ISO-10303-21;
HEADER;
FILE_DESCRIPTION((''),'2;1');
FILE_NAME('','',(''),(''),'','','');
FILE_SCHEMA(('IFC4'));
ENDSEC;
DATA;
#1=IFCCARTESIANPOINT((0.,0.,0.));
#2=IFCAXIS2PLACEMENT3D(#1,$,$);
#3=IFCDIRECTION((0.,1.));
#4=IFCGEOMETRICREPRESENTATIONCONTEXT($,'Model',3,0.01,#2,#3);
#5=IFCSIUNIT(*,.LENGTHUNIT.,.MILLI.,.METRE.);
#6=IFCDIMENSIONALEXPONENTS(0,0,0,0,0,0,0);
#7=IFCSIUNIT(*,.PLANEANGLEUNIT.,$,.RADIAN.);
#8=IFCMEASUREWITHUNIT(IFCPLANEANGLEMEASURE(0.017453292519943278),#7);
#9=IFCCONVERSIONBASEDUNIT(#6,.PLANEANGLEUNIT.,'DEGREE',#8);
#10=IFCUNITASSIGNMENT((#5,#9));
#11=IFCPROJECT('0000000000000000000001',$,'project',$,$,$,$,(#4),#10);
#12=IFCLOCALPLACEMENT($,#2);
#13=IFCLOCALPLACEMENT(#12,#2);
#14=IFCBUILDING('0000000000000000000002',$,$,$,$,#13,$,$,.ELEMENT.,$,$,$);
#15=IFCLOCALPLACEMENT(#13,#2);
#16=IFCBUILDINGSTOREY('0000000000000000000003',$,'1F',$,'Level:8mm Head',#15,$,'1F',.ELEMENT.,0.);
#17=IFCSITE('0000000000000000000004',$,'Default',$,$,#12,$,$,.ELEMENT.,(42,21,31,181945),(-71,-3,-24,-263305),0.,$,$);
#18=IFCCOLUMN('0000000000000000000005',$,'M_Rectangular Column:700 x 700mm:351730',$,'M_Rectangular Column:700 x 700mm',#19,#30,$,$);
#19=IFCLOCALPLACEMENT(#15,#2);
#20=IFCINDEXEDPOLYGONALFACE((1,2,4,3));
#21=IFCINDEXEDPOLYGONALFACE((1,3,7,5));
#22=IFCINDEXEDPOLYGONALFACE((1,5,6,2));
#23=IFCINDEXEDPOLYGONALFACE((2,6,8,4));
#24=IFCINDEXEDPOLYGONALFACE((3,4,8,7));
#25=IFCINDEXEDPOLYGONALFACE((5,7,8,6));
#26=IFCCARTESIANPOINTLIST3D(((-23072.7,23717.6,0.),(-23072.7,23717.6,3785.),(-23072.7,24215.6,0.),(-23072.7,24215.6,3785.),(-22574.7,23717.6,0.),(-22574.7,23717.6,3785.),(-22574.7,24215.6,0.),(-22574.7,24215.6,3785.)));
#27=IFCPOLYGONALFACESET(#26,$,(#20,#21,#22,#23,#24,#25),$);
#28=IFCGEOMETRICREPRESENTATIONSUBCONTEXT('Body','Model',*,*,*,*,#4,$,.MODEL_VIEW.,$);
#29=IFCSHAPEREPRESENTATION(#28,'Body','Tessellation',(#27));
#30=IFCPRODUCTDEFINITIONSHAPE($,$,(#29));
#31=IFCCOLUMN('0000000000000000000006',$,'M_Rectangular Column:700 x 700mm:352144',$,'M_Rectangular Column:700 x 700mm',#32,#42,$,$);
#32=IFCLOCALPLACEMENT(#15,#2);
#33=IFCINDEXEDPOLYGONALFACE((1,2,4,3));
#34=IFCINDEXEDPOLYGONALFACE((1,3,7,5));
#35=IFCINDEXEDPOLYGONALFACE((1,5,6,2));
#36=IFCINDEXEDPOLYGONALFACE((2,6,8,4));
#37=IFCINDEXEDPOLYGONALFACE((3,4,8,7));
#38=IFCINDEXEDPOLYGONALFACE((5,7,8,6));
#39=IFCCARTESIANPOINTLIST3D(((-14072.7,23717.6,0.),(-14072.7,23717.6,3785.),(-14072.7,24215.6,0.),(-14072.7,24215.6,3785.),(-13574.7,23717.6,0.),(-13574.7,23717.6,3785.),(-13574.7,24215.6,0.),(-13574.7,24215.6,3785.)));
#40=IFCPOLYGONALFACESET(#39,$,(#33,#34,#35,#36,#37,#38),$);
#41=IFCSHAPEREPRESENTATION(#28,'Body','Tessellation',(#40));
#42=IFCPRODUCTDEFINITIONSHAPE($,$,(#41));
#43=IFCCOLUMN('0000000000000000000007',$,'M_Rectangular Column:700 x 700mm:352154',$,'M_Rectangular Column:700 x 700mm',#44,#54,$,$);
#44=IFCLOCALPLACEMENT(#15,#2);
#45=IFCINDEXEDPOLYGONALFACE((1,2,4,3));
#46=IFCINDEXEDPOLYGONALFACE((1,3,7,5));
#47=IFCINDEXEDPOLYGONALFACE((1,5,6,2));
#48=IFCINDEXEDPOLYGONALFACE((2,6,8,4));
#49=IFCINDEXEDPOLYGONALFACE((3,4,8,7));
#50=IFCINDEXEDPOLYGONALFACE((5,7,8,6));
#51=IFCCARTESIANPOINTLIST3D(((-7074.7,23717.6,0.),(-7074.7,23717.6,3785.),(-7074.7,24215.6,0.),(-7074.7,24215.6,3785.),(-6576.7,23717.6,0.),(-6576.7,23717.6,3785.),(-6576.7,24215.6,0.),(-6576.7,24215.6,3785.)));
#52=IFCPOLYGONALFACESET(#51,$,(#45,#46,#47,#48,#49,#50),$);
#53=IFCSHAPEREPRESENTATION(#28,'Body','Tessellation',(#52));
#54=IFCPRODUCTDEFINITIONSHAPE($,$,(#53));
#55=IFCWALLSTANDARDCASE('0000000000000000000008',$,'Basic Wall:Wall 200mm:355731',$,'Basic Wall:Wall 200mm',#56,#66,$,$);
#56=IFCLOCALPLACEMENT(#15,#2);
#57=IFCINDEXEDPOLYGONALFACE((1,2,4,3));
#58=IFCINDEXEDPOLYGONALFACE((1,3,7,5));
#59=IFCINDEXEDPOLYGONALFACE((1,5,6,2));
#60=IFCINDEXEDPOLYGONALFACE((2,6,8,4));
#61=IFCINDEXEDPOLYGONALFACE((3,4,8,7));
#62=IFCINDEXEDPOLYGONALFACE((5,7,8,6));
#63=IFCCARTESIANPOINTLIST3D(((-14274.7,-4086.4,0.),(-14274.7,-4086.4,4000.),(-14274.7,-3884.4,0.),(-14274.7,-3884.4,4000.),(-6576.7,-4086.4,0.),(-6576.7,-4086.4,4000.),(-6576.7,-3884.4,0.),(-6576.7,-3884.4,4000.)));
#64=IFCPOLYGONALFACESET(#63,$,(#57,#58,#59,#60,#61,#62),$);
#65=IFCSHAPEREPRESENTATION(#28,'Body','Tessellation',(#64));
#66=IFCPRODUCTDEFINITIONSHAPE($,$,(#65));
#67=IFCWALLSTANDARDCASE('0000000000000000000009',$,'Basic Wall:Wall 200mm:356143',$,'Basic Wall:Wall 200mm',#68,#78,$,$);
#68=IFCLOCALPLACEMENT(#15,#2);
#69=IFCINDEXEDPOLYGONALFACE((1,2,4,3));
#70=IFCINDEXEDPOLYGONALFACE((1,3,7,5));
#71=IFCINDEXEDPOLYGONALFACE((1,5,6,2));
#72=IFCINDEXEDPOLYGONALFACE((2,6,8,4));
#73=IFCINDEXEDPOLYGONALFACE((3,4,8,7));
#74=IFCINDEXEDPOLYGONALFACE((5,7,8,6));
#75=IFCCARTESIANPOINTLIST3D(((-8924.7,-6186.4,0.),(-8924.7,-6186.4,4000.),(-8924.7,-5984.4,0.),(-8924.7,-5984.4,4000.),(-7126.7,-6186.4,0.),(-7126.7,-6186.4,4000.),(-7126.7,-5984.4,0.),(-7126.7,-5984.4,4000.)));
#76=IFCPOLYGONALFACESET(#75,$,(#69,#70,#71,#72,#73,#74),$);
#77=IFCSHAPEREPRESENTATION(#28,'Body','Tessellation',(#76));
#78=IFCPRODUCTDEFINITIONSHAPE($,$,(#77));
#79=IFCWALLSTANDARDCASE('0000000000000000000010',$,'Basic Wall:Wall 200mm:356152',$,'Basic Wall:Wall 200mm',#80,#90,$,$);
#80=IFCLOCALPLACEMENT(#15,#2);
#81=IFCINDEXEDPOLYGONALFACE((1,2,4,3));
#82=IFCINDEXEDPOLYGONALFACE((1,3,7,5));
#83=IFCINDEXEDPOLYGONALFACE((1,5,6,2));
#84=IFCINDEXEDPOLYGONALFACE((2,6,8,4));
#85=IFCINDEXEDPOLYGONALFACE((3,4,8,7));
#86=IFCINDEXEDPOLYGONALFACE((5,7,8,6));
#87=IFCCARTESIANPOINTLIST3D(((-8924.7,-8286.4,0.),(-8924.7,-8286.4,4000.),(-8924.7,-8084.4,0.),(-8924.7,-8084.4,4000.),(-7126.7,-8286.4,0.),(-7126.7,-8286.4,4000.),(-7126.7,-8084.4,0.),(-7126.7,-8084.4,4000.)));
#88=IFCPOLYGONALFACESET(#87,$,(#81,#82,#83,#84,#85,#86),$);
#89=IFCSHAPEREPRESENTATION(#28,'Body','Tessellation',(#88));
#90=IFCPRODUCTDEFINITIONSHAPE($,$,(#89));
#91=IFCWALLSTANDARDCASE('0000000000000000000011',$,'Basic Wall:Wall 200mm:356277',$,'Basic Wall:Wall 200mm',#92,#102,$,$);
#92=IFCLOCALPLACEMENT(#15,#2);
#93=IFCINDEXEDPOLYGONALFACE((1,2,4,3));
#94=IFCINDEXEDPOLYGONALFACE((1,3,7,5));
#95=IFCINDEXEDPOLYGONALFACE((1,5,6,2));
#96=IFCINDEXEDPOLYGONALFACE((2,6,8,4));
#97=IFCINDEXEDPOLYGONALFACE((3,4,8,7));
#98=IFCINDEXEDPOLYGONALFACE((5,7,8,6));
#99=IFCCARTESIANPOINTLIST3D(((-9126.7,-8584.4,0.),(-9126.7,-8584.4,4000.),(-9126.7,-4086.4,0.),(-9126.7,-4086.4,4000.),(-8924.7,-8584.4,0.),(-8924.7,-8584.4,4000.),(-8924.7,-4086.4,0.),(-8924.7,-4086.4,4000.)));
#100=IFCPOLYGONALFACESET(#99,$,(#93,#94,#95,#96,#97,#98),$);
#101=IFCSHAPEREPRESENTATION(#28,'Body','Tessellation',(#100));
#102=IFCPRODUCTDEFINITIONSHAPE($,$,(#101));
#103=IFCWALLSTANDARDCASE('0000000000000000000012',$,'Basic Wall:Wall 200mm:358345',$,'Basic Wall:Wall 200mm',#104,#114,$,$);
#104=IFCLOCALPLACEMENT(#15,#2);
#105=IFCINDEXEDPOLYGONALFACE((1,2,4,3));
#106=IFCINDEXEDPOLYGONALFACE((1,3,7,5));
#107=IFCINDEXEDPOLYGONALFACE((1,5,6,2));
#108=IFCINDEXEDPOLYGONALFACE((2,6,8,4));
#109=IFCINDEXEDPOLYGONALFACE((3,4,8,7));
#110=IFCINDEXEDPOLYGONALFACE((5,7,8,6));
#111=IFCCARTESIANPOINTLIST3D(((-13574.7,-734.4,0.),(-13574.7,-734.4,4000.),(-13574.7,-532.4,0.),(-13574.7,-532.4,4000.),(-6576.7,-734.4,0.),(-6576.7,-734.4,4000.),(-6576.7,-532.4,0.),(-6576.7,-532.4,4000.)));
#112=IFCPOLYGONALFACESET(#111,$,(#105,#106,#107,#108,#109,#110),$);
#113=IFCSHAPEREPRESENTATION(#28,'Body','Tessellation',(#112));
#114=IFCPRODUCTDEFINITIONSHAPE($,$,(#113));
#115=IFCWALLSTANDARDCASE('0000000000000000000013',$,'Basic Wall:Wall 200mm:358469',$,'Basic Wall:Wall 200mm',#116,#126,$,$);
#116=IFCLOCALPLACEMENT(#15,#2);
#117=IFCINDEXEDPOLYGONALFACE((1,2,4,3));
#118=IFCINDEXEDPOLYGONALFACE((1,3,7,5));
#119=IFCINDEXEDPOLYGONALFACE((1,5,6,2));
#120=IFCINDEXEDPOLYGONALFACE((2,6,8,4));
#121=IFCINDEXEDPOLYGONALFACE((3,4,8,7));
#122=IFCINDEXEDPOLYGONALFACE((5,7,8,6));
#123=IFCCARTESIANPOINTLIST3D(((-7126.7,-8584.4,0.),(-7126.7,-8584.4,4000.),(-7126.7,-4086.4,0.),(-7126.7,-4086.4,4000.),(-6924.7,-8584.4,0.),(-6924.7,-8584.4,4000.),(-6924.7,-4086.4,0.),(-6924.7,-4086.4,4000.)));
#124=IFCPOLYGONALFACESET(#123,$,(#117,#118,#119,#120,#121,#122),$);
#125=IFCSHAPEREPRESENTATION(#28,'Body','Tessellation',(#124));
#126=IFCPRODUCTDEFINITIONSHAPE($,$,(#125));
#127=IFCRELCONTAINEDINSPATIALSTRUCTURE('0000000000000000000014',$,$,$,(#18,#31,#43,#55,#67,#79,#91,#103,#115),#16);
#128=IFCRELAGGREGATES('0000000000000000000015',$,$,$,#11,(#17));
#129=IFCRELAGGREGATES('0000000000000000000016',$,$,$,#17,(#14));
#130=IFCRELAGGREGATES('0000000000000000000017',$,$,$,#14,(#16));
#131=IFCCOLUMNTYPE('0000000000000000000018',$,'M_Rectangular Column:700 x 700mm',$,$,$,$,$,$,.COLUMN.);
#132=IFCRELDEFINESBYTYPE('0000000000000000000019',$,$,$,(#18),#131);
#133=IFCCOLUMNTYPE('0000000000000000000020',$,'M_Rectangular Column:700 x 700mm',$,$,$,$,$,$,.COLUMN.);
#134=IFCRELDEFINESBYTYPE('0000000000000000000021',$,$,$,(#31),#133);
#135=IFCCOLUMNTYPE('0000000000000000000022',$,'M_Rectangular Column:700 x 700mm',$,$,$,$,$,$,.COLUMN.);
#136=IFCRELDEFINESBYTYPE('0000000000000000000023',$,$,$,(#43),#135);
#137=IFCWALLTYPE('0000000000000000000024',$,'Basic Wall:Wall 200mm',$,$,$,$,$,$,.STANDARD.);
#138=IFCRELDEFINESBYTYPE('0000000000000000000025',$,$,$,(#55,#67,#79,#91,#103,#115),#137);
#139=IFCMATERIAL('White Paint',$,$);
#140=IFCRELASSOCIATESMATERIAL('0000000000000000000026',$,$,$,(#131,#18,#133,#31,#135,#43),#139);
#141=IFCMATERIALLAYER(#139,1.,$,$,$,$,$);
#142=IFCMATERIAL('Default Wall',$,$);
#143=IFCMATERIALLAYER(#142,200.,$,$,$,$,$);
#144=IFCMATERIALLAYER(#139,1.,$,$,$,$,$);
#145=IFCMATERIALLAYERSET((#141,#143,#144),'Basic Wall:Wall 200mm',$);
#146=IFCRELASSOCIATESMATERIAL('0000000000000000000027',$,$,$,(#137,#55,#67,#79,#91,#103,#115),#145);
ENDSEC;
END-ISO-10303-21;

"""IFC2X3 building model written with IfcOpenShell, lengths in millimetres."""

from ifc_helpers import new_model, entity, si_unit, converted_unit, direction, frame, frame_2d, origin, place, context, subcontext, project, spatial, rectangle, extrude, source, transform, mapped, material, layer, layer_set, layer_usage, type_object, type_shapes, element, save


model = new_model("IFC2X3")

# Units and contexts
model_context = context("Model", 3, precision=0.01, world=origin(), true_north=direction((0.0, 1.0)))
body_context = subcontext(model_context, "Body", "Model", "MODEL_VIEW")
ifc_project = project(units=[si_unit("LENGTHUNIT", "METRE", prefix="MILLI"), converted_unit("PLANEANGLEUNIT", "DEGREE", entity("IfcPlaneAngleMeasure", 0.017453292519943278), si_unit("PLANEANGLEUNIT", "RADIAN"), dimensions=[0, 0, 0, 0, 0, 0, 0])], contexts=[model_context])

# Site, building, storey
site_placement = place(None, origin())
site = spatial("IfcSite", under=ifc_project, at=site_placement, Name="Default", CompositionType="ELEMENT", RefLatitude=(42, 21, 31, 181945), RefLongitude=(-71, -3, -24, -263305), RefElevation=0.0)
building_placement = place(site_placement, origin())
building = spatial("IfcBuilding", under=site, at=building_placement, CompositionType="ELEMENT")
storey_placement = place(building_placement, origin())
storey = spatial("IfcBuildingStorey", under=building, at=storey_placement, Name="1F", ObjectType="Level:8mm Head", LongName="1F", CompositionType="ELEMENT", Elevation=0.0)

# Columns
ifc_material_1 = material(Name="White Paint")
column_type_1 = type_object("IfcColumnType", Name="M_Rectangular Column:700 x 700mm", PredefinedType="COLUMN", material=ifc_material_1)
shared_shape_1 = source(origin(), body_context, "Body", "SweptSolid", [
    extrude(rectangle(XDim=498.0, YDim=498.0, at=frame_2d((0.0, 0.0), x_axis=(1.0, 0.0))), frame((-22823.7, 23966.6, 0.0), z_axis=(0.0, 0.0, 1.0), x_axis=(0.0, 1.0, 0.0)), (0.0, 0.0, 1.0), 3785.0),
])
type_shapes(column_type_1, [shared_shape_1])
column_1_placement = place(storey_placement, origin())
element("IfcColumn", 1, at=column_1_placement, inside=storey, type_object=column_type_1, material=ifc_material_1, Name="M_Rectangular Column:700 x 700mm:351730", ObjectType="M_Rectangular Column:700 x 700mm", context=body_context, shape_type="MappedRepresentation", body=[
    mapped(shared_shape_1, transform((0.0, 0.0, 0.0), scale=1.0)),
])
column_type_2 = type_object("IfcColumnType", Name="M_Rectangular Column:700 x 700mm", PredefinedType="COLUMN", material=ifc_material_1)
shared_shape_2 = source(origin(), body_context, "Body", "SweptSolid", [
    extrude(rectangle(XDim=498.0, YDim=498.0, at=frame_2d((0.0, 0.0), x_axis=(1.0, 0.0))), frame((-13823.7, 23966.6, 0.0), z_axis=(0.0, 0.0, 1.0), x_axis=(-1.0, 0.0, 0.0)), (0.0, 0.0, 1.0), 3785.0),
])
type_shapes(column_type_2, [shared_shape_2])
column_2_placement = place(storey_placement, origin())
element("IfcColumn", 2, at=column_2_placement, inside=storey, type_object=column_type_2, material=ifc_material_1, Name="M_Rectangular Column:700 x 700mm:352144", ObjectType="M_Rectangular Column:700 x 700mm", context=body_context, shape_type="MappedRepresentation", body=[
    mapped(shared_shape_2, transform((0.0, 0.0, 0.0), scale=1.0)),
])
column_type_3 = type_object("IfcColumnType", Name="M_Rectangular Column:700 x 700mm", PredefinedType="COLUMN", material=ifc_material_1)
shared_shape_3 = source(origin(), body_context, "Body", "SweptSolid", [
    extrude(rectangle(XDim=498.0, YDim=498.0, at=frame_2d((0.0, 0.0), x_axis=(1.0, 0.0))), frame((-6825.7, 23966.6, 0.0)), (0.0, 0.0, 1.0), 3785.0),
])
type_shapes(column_type_3, [shared_shape_3])
column_3_placement = place(storey_placement, origin())
element("IfcColumn", 3, at=column_3_placement, inside=storey, type_object=column_type_3, material=ifc_material_1, Name="M_Rectangular Column:700 x 700mm:352154", ObjectType="M_Rectangular Column:700 x 700mm", context=body_context, shape_type="MappedRepresentation", body=[
    mapped(shared_shape_3, transform((0.0, 0.0, 0.0), scale=1.0)),
])

# Wall
ifc_layer_1 = layer(ifc_material_1, 1.0)
ifc_material_2 = material(Name="Default Wall")
ifc_layer_2 = layer(ifc_material_2, 200.0)
ifc_layer_3 = layer(ifc_material_1, 1.0)
ifc_layer_set = layer_set([ifc_layer_1, ifc_layer_2, ifc_layer_3], Name="Basic Wall:Wall 200mm")
ifc_layer_usage_1 = layer_usage(ifc_layer_set, "AXIS2", "NEGATIVE", 101.0)
wall_type = type_object("IfcWallType", Name="Basic Wall:Wall 200mm", PredefinedType="STANDARD", material=ifc_layer_set)
wall_1_placement = place(storey_placement, frame((-6576.7, -3985.4, 0.0), z_axis=(0.0, 0.0, 1.0), x_axis=(-1.0, 0.0, 0.0)))
element("IfcWallStandardCase", 4, at=wall_1_placement, inside=storey, type_object=wall_type, material=ifc_layer_usage_1, Name="Basic Wall:Wall 200mm:355731", ObjectType="Basic Wall:Wall 200mm", context=body_context, shape_type="SweptSolid", body=[
    extrude(rectangle(XDim=7698.0, YDim=202.0, at=frame_2d((3849.0, 0.0), x_axis=(-1.0, 0.0))), origin(), (0.0, 0.0, 1.0), 4000.0),
])

# Walls
ifc_layer_usage_2 = layer_usage(ifc_layer_set, "AXIS2", "NEGATIVE", 101.0)
wall_2_placement = place(storey_placement, frame((-7126.7, -6085.4, 0.0), z_axis=(0.0, 0.0, 1.0), x_axis=(-1.0, 0.0, 0.0)))
element("IfcWallStandardCase", 5, at=wall_2_placement, inside=storey, type_object=wall_type, material=ifc_layer_usage_2, Name="Basic Wall:Wall 200mm:356143", ObjectType="Basic Wall:Wall 200mm", context=body_context, shape_type="SweptSolid", body=[
    extrude(rectangle(XDim=1798.0, YDim=202.0, at=frame_2d((899.0, 0.0), x_axis=(-1.0, 0.0))), origin(), (0.0, 0.0, 1.0), 4000.0),
])
ifc_layer_usage_3 = layer_usage(ifc_layer_set, "AXIS2", "NEGATIVE", 101.0)
wall_3_placement = place(storey_placement, frame((-7126.7, -8185.4, 0.0), z_axis=(0.0, 0.0, 1.0), x_axis=(-1.0, 0.0, 0.0)))
element("IfcWallStandardCase", 6, at=wall_3_placement, inside=storey, type_object=wall_type, material=ifc_layer_usage_3, Name="Basic Wall:Wall 200mm:356152", ObjectType="Basic Wall:Wall 200mm", context=body_context, shape_type="SweptSolid", body=[
    extrude(rectangle(XDim=1798.0, YDim=202.0, at=frame_2d((899.0, 0.0), x_axis=(-1.0, 0.0))), origin(), (0.0, 0.0, 1.0), 4000.0),
])
ifc_layer_usage_4 = layer_usage(ifc_layer_set, "AXIS2", "NEGATIVE", 101.0)
wall_4_placement = place(storey_placement, frame((-9025.7, -4086.4, 0.0), z_axis=(0.0, 0.0, 1.0), x_axis=(0.0, -1.0, 0.0)))
element("IfcWallStandardCase", 7, at=wall_4_placement, inside=storey, type_object=wall_type, material=ifc_layer_usage_4, Name="Basic Wall:Wall 200mm:356277", ObjectType="Basic Wall:Wall 200mm", context=body_context, shape_type="SweptSolid", body=[
    extrude(rectangle(XDim=4498.0, YDim=202.0, at=frame_2d((2249.0, 0.0), x_axis=(-1.0, 0.0))), origin(), (0.0, 0.0, 1.0), 4000.0),
])
ifc_layer_usage_5 = layer_usage(ifc_layer_set, "AXIS2", "NEGATIVE", 101.0)
wall_5_placement = place(storey_placement, frame((-13574.7, -633.4, 0.0)))
element("IfcWallStandardCase", 8, at=wall_5_placement, inside=storey, type_object=wall_type, material=ifc_layer_usage_5, Name="Basic Wall:Wall 200mm:358345", ObjectType="Basic Wall:Wall 200mm", context=body_context, shape_type="SweptSolid", body=[
    extrude(rectangle(XDim=6998.0, YDim=202.0, at=frame_2d((3499.0, 0.0), x_axis=(-1.0, 0.0))), origin(), (0.0, 0.0, 1.0), 4000.0),
])
ifc_layer_usage_6 = layer_usage(ifc_layer_set, "AXIS2", "NEGATIVE", 101.0)
wall_6_placement = place(storey_placement, frame((-7025.7, -4086.4, 0.0), z_axis=(0.0, 0.0, 1.0), x_axis=(0.0, -1.0, 0.0)))
element("IfcWallStandardCase", 9, at=wall_6_placement, inside=storey, type_object=wall_type, material=ifc_layer_usage_6, Name="Basic Wall:Wall 200mm:358469", ObjectType="Basic Wall:Wall 200mm", context=body_context, shape_type="SweptSolid", body=[
    extrude(rectangle(XDim=4498.0, YDim=202.0, at=frame_2d((2249.0, 0.0), x_axis=(-1.0, 0.0))), origin(), (0.0, 0.0, 1.0), 4000.0),
])

save(model, "model.ifc")
